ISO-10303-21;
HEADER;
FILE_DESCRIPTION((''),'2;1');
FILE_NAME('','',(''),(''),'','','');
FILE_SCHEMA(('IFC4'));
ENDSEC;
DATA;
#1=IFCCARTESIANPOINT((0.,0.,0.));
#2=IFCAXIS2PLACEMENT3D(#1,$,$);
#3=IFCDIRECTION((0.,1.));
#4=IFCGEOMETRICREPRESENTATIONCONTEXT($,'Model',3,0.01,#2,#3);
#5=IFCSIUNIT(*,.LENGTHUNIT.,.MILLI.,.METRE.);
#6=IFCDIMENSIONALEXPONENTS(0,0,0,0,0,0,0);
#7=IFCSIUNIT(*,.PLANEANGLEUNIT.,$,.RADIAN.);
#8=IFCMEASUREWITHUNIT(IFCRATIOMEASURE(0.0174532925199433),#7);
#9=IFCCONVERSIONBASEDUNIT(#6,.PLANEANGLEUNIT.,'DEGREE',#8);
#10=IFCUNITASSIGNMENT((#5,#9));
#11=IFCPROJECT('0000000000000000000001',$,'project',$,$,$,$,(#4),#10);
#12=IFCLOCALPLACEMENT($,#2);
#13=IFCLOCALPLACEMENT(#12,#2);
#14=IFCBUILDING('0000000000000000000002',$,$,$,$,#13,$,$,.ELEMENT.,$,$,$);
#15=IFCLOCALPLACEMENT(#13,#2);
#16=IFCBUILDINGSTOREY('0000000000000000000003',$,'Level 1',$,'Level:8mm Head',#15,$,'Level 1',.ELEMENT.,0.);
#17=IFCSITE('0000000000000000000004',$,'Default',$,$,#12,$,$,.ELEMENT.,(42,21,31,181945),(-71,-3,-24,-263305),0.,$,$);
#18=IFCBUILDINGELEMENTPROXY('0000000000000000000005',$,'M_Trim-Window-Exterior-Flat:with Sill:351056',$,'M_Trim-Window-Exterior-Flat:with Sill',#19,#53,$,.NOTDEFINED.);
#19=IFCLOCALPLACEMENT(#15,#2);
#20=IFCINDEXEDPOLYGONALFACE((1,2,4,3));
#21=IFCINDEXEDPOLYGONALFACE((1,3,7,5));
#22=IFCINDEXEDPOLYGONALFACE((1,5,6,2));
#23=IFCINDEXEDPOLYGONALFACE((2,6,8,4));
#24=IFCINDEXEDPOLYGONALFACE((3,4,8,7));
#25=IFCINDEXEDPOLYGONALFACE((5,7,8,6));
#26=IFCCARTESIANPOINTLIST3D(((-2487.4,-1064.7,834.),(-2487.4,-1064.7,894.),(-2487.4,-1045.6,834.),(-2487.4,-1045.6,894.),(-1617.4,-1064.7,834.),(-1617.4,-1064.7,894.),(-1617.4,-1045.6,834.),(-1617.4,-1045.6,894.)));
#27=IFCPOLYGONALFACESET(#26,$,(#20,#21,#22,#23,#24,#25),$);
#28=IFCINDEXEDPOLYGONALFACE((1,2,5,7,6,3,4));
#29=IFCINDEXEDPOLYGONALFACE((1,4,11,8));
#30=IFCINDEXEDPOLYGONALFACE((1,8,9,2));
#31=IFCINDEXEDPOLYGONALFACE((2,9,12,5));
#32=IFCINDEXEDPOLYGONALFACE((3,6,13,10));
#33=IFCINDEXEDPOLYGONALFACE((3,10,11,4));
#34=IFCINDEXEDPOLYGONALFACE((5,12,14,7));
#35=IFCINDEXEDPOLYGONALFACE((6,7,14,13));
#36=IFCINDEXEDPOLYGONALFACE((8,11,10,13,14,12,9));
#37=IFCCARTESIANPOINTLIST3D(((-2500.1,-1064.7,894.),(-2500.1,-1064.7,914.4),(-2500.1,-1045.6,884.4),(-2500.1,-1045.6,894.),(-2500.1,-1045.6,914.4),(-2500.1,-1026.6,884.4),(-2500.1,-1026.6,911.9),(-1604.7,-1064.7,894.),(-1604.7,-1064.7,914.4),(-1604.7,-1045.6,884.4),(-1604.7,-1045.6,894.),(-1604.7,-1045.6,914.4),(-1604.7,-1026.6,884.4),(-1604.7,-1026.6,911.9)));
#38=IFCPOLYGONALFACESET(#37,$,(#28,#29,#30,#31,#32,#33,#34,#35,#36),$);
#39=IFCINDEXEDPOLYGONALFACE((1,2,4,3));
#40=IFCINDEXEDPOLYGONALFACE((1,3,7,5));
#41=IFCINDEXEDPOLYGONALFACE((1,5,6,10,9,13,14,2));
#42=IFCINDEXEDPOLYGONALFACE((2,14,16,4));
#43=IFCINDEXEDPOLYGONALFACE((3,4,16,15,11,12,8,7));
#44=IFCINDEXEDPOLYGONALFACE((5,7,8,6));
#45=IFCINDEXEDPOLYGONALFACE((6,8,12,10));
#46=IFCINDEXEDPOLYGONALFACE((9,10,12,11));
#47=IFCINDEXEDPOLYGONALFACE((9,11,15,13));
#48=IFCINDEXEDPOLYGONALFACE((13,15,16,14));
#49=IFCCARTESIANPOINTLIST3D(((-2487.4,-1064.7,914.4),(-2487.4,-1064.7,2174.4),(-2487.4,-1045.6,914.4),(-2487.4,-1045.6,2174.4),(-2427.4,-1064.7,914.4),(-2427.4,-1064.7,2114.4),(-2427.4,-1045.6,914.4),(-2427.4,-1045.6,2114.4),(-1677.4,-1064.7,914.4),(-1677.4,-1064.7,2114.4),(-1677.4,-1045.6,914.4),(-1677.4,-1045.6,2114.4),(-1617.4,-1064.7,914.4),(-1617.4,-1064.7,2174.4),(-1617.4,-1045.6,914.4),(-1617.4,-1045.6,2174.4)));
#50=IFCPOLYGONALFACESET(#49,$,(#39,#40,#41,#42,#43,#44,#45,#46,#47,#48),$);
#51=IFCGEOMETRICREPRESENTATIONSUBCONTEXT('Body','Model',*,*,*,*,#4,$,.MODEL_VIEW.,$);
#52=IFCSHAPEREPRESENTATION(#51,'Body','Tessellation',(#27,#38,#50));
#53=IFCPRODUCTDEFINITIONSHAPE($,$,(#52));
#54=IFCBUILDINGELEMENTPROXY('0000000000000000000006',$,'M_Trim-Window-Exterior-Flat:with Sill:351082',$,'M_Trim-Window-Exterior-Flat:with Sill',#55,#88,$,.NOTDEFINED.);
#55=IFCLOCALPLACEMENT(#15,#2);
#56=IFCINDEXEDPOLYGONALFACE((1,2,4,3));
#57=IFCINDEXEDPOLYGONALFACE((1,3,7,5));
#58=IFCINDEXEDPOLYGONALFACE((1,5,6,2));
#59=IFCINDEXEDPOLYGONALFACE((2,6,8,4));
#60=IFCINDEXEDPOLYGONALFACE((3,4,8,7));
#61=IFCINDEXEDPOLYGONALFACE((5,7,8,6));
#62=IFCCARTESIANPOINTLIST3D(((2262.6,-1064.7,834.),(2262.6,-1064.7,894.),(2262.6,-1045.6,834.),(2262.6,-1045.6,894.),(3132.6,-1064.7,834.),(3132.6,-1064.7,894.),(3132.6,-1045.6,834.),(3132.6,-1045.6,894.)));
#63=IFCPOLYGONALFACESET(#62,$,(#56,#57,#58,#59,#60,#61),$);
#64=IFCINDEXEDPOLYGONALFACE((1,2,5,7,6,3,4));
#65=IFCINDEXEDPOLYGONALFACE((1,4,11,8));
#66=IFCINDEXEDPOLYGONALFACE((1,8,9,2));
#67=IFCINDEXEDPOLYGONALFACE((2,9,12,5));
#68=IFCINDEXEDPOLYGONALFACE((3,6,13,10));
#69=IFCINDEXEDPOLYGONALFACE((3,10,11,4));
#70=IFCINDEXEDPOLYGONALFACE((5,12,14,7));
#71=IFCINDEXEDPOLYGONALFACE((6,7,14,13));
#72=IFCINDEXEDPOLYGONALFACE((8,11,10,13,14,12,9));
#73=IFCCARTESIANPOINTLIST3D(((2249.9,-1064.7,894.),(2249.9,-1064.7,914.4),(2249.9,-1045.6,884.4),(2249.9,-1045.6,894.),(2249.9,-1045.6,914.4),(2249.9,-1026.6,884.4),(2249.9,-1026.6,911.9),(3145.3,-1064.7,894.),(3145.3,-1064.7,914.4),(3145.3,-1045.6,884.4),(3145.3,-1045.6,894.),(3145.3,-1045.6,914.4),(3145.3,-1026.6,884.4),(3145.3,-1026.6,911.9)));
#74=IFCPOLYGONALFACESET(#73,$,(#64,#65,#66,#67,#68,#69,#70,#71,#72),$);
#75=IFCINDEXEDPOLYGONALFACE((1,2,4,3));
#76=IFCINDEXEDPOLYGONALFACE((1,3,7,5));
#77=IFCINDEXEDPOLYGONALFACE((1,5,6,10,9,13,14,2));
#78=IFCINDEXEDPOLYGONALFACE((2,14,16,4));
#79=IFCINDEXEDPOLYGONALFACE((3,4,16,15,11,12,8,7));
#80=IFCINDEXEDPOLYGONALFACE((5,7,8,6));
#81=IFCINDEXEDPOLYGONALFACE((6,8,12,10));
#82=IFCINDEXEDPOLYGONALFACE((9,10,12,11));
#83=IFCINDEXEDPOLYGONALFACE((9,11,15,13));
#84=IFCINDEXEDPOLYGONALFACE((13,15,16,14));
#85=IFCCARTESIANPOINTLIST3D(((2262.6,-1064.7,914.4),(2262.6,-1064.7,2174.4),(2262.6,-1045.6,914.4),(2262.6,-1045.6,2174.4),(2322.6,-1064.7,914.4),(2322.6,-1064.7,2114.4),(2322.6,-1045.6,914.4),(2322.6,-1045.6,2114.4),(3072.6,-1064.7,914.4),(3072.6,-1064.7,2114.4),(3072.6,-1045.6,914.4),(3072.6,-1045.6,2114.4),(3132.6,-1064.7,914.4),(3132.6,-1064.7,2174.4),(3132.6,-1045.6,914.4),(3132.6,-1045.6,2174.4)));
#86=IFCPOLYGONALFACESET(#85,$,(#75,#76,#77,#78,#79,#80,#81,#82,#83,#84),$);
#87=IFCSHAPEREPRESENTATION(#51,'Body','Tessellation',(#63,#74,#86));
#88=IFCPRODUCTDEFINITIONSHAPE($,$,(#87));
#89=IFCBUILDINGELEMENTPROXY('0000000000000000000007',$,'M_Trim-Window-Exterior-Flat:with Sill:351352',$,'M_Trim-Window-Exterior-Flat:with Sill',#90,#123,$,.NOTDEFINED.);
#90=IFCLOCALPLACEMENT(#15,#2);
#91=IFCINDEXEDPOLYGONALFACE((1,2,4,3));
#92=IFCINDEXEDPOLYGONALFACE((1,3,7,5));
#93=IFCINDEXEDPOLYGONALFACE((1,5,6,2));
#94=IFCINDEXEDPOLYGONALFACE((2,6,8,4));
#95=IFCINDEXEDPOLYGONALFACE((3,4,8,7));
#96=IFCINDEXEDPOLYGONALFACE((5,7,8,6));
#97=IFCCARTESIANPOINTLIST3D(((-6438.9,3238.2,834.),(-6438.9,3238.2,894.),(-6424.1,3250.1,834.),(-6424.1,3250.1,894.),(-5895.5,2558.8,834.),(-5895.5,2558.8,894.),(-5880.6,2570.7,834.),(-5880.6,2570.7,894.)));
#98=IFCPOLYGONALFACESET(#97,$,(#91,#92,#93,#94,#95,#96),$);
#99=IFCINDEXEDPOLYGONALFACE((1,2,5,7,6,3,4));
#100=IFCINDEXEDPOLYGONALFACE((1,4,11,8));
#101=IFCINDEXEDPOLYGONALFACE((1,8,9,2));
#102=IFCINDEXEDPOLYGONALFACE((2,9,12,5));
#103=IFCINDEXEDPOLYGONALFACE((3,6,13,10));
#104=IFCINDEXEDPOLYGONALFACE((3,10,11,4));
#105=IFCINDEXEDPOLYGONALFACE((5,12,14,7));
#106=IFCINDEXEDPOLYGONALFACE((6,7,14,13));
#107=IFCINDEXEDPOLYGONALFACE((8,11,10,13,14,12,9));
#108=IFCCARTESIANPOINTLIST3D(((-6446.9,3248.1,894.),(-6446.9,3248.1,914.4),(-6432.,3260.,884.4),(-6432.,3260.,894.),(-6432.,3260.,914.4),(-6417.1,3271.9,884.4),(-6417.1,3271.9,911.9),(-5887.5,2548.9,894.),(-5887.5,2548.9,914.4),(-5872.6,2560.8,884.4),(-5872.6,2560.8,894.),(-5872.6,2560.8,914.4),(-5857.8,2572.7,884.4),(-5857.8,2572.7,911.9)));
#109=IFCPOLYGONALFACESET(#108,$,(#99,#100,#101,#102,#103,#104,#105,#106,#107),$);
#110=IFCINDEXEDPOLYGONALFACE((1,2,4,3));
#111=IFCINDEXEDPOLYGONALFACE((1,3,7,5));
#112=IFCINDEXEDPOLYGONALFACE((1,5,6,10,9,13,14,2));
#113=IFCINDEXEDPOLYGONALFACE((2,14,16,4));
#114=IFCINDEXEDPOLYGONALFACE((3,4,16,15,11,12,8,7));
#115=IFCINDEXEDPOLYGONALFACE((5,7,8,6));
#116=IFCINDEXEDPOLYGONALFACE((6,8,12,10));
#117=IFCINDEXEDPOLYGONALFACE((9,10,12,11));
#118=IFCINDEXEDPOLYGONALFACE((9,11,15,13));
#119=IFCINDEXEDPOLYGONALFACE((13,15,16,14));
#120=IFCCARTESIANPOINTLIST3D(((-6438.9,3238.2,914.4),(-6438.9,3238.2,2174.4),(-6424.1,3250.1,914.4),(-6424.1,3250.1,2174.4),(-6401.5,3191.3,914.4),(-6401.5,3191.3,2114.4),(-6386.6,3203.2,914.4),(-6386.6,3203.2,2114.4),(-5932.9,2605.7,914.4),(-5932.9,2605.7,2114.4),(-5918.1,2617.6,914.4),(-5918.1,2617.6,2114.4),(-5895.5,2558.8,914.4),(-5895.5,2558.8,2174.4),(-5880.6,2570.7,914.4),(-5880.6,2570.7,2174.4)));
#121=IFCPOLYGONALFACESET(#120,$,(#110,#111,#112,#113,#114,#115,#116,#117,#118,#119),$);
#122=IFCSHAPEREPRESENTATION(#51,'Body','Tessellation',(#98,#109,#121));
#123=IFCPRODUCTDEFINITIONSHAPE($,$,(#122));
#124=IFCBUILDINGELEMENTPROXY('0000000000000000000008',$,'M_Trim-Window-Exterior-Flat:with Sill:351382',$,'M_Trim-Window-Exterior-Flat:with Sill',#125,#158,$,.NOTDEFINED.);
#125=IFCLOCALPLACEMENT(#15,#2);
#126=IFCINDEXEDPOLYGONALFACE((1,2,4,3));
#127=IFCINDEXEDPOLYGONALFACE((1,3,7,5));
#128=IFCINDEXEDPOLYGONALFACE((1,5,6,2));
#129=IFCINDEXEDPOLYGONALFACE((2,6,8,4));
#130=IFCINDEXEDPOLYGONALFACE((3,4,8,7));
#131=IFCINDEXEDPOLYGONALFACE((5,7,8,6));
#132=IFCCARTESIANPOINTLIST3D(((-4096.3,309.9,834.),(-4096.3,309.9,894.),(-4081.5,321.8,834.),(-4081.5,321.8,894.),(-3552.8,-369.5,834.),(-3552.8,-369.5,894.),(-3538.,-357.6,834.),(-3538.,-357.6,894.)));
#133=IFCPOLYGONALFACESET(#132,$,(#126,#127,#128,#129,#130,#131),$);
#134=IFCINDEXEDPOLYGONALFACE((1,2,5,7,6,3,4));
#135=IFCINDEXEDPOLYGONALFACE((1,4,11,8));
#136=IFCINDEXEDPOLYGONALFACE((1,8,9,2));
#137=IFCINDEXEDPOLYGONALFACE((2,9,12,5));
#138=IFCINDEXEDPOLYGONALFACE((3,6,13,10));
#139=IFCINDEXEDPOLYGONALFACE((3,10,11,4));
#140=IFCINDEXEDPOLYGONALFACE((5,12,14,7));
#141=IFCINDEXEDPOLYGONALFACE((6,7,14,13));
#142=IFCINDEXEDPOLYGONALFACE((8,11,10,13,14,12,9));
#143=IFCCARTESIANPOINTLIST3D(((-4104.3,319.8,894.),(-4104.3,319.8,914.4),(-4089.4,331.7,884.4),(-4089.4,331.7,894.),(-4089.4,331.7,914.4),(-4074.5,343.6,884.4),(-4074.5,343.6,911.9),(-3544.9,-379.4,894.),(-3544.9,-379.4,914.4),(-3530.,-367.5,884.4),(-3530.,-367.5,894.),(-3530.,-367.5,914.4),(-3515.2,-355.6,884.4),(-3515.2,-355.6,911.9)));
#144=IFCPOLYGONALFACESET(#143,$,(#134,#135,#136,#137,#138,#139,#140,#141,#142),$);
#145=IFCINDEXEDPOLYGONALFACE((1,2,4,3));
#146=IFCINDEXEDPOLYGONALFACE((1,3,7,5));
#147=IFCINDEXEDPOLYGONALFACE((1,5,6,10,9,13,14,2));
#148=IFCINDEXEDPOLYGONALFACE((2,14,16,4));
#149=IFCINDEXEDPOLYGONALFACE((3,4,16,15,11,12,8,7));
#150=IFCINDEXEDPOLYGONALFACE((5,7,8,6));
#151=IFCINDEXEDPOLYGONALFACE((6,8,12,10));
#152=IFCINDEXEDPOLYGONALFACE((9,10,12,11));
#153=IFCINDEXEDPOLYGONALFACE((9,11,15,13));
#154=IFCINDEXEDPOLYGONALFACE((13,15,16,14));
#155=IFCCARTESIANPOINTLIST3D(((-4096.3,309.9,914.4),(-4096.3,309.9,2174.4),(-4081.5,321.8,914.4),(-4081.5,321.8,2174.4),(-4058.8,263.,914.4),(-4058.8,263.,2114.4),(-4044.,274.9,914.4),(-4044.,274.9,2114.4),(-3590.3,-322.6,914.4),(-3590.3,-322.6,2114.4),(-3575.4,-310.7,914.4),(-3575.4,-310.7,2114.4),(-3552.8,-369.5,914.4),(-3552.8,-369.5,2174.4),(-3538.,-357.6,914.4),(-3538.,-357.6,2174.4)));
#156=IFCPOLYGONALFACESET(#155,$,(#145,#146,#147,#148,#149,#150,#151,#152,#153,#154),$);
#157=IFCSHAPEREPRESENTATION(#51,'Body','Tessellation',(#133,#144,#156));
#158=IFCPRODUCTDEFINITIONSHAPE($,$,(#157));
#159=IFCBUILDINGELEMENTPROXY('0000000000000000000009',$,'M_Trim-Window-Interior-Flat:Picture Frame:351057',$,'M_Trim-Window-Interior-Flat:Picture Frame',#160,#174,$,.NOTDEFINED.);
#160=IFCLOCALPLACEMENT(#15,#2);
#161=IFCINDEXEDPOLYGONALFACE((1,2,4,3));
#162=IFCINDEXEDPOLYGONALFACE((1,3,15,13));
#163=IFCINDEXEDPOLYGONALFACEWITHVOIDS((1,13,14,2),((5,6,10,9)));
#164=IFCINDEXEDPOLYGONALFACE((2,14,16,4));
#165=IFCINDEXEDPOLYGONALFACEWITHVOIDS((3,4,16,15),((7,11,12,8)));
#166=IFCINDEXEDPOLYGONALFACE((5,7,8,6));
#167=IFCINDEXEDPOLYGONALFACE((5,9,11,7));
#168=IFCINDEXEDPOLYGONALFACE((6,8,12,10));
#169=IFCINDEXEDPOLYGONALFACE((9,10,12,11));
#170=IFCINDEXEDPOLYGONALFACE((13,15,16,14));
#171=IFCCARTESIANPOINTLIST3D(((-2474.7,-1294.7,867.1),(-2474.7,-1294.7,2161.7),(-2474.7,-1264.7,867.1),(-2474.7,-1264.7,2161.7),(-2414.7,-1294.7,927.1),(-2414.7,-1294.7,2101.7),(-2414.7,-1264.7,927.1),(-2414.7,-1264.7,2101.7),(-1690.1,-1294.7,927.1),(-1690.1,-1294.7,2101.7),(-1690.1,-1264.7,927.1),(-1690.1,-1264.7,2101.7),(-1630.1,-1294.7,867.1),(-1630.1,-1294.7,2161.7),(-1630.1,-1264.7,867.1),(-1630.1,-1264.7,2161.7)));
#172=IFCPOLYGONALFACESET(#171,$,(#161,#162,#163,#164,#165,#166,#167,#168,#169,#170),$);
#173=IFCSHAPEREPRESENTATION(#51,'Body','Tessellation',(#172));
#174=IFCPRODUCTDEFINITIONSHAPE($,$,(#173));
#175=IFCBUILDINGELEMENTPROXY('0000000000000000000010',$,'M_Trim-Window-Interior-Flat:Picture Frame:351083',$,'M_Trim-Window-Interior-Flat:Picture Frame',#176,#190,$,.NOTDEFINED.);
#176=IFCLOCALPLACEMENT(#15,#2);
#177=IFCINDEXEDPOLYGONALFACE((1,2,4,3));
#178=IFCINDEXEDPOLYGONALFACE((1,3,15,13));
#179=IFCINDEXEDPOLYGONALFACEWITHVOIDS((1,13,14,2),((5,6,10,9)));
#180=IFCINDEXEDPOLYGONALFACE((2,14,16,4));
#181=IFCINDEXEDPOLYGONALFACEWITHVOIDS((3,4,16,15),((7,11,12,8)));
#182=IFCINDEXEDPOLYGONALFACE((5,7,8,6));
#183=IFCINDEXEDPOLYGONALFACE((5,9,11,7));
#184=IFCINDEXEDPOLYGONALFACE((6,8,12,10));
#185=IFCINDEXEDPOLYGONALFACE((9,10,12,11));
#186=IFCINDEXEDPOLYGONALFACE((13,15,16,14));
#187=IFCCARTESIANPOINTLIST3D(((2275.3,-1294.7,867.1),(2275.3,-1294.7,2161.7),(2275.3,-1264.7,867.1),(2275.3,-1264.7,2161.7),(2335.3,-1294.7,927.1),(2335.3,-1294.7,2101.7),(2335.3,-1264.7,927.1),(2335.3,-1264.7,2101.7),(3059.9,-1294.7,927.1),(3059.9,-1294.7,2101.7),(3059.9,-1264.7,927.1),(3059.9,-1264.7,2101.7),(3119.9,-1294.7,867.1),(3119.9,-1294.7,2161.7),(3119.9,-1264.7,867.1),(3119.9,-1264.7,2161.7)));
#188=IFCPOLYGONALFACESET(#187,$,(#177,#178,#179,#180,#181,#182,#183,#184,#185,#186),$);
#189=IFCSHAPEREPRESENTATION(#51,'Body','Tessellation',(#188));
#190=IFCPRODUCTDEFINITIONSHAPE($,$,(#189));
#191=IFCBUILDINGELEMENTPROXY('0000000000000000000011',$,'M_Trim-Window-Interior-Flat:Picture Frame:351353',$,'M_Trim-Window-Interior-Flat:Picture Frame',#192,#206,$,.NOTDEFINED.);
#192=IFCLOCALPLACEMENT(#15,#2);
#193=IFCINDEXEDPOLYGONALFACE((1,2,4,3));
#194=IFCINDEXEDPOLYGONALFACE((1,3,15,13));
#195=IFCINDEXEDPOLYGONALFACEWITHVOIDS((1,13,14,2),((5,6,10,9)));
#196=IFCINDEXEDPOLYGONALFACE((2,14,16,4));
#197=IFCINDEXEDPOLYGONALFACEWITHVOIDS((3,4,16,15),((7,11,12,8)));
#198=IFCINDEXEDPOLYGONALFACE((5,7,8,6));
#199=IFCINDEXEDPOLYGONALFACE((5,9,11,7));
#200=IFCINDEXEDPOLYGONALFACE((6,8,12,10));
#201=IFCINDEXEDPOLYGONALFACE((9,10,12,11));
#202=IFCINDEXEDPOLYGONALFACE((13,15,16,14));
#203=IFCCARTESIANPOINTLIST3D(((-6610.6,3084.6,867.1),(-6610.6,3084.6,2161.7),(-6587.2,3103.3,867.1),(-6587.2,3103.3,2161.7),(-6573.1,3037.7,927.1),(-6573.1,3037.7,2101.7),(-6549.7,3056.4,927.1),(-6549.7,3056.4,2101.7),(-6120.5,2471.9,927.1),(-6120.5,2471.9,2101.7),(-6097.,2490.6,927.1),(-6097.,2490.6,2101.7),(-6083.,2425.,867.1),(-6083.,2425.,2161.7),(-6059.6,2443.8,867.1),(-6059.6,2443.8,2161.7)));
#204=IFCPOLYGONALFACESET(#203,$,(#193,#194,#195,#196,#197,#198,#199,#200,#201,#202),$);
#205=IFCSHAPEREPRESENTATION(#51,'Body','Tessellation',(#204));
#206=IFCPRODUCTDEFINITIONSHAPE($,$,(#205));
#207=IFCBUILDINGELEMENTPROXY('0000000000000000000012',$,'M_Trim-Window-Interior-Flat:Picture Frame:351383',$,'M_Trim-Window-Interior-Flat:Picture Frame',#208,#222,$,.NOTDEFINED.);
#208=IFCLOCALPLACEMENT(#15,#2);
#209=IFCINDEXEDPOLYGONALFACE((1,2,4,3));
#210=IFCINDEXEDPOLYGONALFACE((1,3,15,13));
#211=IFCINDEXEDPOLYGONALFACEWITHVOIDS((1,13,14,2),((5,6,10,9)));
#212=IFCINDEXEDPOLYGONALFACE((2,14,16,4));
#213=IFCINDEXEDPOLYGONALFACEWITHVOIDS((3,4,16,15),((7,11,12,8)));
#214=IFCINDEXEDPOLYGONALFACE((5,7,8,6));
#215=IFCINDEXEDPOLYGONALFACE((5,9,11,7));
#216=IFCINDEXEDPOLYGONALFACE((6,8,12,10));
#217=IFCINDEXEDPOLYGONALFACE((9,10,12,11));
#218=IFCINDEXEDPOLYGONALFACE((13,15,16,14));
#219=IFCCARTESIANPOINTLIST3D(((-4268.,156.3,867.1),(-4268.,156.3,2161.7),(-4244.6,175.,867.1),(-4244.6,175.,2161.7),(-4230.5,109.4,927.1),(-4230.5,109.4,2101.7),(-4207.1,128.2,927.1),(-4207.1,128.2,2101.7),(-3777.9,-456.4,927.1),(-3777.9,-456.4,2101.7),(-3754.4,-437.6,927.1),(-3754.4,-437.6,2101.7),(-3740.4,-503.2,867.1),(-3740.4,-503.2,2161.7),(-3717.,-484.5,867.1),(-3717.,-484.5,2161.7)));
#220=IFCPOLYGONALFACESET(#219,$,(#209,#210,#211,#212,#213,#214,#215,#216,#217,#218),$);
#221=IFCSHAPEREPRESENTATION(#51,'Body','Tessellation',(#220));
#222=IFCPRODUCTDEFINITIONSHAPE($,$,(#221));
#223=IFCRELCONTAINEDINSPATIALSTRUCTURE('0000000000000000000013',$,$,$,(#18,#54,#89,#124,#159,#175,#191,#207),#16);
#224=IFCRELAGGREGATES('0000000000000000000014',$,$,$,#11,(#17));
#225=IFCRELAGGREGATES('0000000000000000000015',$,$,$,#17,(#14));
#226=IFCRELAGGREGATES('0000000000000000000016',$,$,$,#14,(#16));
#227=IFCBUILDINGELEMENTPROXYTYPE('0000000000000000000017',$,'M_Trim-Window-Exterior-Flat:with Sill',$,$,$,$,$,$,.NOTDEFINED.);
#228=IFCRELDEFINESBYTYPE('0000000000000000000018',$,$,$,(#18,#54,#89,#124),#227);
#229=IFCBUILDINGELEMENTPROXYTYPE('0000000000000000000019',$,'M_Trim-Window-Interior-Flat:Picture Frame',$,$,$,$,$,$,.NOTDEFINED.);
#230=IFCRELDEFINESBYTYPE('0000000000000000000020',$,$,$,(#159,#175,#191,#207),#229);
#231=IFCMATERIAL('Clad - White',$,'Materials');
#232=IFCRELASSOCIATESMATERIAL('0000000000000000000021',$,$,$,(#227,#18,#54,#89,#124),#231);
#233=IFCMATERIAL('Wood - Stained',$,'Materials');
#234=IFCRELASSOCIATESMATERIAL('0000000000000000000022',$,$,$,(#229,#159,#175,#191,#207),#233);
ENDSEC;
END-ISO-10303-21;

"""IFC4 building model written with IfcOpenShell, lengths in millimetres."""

from ifc_helpers import new_model, entity, si_unit, converted_unit, direction, frame, frame_2d, origin, place, context, subcontext, project, spatial, polyline, rectangle, outline, extrude, source, transform, mapped, material, type_object, type_shapes, element, save


model = new_model("IFC4")

# Units and contexts
model_context = context("Model", 3, precision=0.01, world=origin(), true_north=direction((0.0, 1.0)))
body_context = subcontext(model_context, "Body", "Model", "MODEL_VIEW")
ifc_project = project(units=[si_unit("LENGTHUNIT", "METRE", prefix="MILLI"), converted_unit("PLANEANGLEUNIT", "DEGREE", entity("IfcRatioMeasure", 0.0174532925199433), si_unit("PLANEANGLEUNIT", "RADIAN"), dimensions=[0, 0, 0, 0, 0, 0, 0])], contexts=[model_context])

# Site, building, storey
site_placement = place(None, origin())
site = spatial("IfcSite", under=ifc_project, at=site_placement, Name="Default", CompositionType="ELEMENT", RefLatitude=(42, 21, 31, 181945), RefLongitude=(-71, -3, -24, -263305), RefElevation=0.0)
building_placement = place(site_placement, origin())
building = spatial("IfcBuilding", under=site, at=building_placement, CompositionType="ELEMENT")
storey_placement = place(building_placement, origin())
storey = spatial("IfcBuildingStorey", under=building, at=storey_placement, Name="Level 1", ObjectType="Level:8mm Head", LongName="Level 1", CompositionType="ELEMENT", Elevation=0.0)

# Shared definitions
ifc_material_1 = material(Name="Wood - Stained", Category="Materials")

# Building element proxies
ifc_material_2 = material(Name="Clad - White", Category="Materials")
building_element_proxy_type_1 = type_object("IfcBuildingElementProxyType", Name="M_Trim-Window-Exterior-Flat:with Sill", PredefinedType="NOTDEFINED", material=ifc_material_2)
shared_shape_1 = source(origin(), body_context, "Body", "SweptSolid", [
    extrude(rectangle(XDim=870.0, YDim=60.0, at=frame_2d((0.0, 0.0), x_axis=(1.0, 0.0))), frame((0.0, -1250.4, 0.0), z_axis=(0.0, 0.0, 1.0), x_axis=(-1.0, 0.0, 0.0)), (0.0, 0.0, 1.0), 19.1),
    extrude(outline(polyline([(-19.0, -15.2), (0.0, -15.2), (0.0, -5.7), (19.0, -5.7), (19.0, 14.8), (0.0, 14.8), (-19.0, 12.3), (-19.0, -15.2)])), frame((-447.7, -1214.8, 19.0), z_axis=(1.0, 0.0, 0.0), x_axis=(0.0, 0.0, -1.0)), (0.0, 0.0, 1.0), 895.4),
    extrude(outline(polyline([(-645.0, -435.0), (615.0, -435.0), (615.0, -375.0), (-585.0, -375.0), (-585.0, 375.0), (615.0, 375.0), (615.0, 435.0), (-645.0, 435.0), (-645.0, -435.0)])), frame((0.0, -585.0, 0.0), z_axis=(0.0, 0.0, 1.0), x_axis=(0.0, -1.0, 0.0)), (0.0, 0.0, 1.0), 19.1),
])
type_shapes(building_element_proxy_type_1, [shared_shape_1])
for number, where, z_axis, x_axis, name in (
    (1, (-2052.4, -1064.7, 2114.4), (0.0, 1.0, 0.0), (-1.0, 0.0, 0.0), "M_Trim-Window-Exterior-Flat:with Sill:351056"),
    (2, (2697.6, -1064.7, 2114.4), (0.0, 1.0, 0.0), (-1.0, 0.0, 0.0), "M_Trim-Window-Exterior-Flat:with Sill:351082"),
    (3, (-6167.2, 2898.5, 2114.4), (0.780869, 0.624695, 0.0), (-0.624695, 0.780869, 0.0), "M_Trim-Window-Exterior-Flat:with Sill:351352"),
    (4, (-3824.6, -29.8, 2114.4), (0.780869, 0.624695, 0.0), (-0.624695, 0.780869, 0.0), "M_Trim-Window-Exterior-Flat:with Sill:351382"),
):
    element("IfcBuildingElementProxy", number, at=place(storey_placement, frame(where, z_axis=z_axis, x_axis=x_axis)), inside=storey, type_object=building_element_proxy_type_1, material=ifc_material_2, Name=name, ObjectType="M_Trim-Window-Exterior-Flat:with Sill", PredefinedType="NOTDEFINED", context=body_context, shape_type="MappedRepresentation", body=[
        mapped(shared_shape_1, transform((0.0, 0.0, 0.0), scale=1.0)),
    ])
building_element_proxy_type_2 = type_object("IfcBuildingElementProxyType", Name="M_Trim-Window-Interior-Flat:Picture Frame", PredefinedType="NOTDEFINED", material=ifc_material_1)
shared_shape_2 = source(origin(), body_context, "Body", "SweptSolid", [
    extrude(outline(polyline([(-422.3, -647.3), (422.3, -647.3), (422.3, 647.3), (-422.3, 647.3), (-422.3, -647.3)]), holes=[polyline([(-362.3, -587.3), (-362.3, 587.3), (362.3, 587.3), (362.3, -587.3), (-362.3, -587.3)])]), frame((0.0, -600.0, 0.0), z_axis=(0.0, 0.0, 1.0), x_axis=(-1.0, 0.0, 0.0)), (0.0, 0.0, 1.0), 30.0),
])
type_shapes(building_element_proxy_type_2, [shared_shape_2])
for number, where, z_axis, x_axis, name in (
    (5, (-2052.4, -1264.7, 2114.4), (0.0, -1.0, 0.0), (1.0, 0.0, 0.0), "M_Trim-Window-Interior-Flat:Picture Frame:351057"),
    (6, (2697.6, -1264.7, 2114.4), (0.0, -1.0, 0.0), (1.0, 0.0, 0.0), "M_Trim-Window-Interior-Flat:Picture Frame:351083"),
    (7, (-6323.4, 2773.5, 2114.4), (-0.780869, -0.624695, 0.0), (0.624695, -0.780869, 0.0), "M_Trim-Window-Interior-Flat:Picture Frame:351353"),
    (8, (-3980.8, -154.7, 2114.4), (-0.780869, -0.624695, 0.0), (0.624695, -0.780869, 0.0), "M_Trim-Window-Interior-Flat:Picture Frame:351383"),
):
    element("IfcBuildingElementProxy", number, at=place(storey_placement, frame(where, z_axis=z_axis, x_axis=x_axis)), inside=storey, type_object=building_element_proxy_type_2, material=ifc_material_1, Name=name, ObjectType="M_Trim-Window-Interior-Flat:Picture Frame", PredefinedType="NOTDEFINED", context=body_context, shape_type="MappedRepresentation", body=[
        mapped(shared_shape_2, transform((0.0, 0.0, 0.0), scale=1.0)),
    ])

save(model, "model.ifc")
